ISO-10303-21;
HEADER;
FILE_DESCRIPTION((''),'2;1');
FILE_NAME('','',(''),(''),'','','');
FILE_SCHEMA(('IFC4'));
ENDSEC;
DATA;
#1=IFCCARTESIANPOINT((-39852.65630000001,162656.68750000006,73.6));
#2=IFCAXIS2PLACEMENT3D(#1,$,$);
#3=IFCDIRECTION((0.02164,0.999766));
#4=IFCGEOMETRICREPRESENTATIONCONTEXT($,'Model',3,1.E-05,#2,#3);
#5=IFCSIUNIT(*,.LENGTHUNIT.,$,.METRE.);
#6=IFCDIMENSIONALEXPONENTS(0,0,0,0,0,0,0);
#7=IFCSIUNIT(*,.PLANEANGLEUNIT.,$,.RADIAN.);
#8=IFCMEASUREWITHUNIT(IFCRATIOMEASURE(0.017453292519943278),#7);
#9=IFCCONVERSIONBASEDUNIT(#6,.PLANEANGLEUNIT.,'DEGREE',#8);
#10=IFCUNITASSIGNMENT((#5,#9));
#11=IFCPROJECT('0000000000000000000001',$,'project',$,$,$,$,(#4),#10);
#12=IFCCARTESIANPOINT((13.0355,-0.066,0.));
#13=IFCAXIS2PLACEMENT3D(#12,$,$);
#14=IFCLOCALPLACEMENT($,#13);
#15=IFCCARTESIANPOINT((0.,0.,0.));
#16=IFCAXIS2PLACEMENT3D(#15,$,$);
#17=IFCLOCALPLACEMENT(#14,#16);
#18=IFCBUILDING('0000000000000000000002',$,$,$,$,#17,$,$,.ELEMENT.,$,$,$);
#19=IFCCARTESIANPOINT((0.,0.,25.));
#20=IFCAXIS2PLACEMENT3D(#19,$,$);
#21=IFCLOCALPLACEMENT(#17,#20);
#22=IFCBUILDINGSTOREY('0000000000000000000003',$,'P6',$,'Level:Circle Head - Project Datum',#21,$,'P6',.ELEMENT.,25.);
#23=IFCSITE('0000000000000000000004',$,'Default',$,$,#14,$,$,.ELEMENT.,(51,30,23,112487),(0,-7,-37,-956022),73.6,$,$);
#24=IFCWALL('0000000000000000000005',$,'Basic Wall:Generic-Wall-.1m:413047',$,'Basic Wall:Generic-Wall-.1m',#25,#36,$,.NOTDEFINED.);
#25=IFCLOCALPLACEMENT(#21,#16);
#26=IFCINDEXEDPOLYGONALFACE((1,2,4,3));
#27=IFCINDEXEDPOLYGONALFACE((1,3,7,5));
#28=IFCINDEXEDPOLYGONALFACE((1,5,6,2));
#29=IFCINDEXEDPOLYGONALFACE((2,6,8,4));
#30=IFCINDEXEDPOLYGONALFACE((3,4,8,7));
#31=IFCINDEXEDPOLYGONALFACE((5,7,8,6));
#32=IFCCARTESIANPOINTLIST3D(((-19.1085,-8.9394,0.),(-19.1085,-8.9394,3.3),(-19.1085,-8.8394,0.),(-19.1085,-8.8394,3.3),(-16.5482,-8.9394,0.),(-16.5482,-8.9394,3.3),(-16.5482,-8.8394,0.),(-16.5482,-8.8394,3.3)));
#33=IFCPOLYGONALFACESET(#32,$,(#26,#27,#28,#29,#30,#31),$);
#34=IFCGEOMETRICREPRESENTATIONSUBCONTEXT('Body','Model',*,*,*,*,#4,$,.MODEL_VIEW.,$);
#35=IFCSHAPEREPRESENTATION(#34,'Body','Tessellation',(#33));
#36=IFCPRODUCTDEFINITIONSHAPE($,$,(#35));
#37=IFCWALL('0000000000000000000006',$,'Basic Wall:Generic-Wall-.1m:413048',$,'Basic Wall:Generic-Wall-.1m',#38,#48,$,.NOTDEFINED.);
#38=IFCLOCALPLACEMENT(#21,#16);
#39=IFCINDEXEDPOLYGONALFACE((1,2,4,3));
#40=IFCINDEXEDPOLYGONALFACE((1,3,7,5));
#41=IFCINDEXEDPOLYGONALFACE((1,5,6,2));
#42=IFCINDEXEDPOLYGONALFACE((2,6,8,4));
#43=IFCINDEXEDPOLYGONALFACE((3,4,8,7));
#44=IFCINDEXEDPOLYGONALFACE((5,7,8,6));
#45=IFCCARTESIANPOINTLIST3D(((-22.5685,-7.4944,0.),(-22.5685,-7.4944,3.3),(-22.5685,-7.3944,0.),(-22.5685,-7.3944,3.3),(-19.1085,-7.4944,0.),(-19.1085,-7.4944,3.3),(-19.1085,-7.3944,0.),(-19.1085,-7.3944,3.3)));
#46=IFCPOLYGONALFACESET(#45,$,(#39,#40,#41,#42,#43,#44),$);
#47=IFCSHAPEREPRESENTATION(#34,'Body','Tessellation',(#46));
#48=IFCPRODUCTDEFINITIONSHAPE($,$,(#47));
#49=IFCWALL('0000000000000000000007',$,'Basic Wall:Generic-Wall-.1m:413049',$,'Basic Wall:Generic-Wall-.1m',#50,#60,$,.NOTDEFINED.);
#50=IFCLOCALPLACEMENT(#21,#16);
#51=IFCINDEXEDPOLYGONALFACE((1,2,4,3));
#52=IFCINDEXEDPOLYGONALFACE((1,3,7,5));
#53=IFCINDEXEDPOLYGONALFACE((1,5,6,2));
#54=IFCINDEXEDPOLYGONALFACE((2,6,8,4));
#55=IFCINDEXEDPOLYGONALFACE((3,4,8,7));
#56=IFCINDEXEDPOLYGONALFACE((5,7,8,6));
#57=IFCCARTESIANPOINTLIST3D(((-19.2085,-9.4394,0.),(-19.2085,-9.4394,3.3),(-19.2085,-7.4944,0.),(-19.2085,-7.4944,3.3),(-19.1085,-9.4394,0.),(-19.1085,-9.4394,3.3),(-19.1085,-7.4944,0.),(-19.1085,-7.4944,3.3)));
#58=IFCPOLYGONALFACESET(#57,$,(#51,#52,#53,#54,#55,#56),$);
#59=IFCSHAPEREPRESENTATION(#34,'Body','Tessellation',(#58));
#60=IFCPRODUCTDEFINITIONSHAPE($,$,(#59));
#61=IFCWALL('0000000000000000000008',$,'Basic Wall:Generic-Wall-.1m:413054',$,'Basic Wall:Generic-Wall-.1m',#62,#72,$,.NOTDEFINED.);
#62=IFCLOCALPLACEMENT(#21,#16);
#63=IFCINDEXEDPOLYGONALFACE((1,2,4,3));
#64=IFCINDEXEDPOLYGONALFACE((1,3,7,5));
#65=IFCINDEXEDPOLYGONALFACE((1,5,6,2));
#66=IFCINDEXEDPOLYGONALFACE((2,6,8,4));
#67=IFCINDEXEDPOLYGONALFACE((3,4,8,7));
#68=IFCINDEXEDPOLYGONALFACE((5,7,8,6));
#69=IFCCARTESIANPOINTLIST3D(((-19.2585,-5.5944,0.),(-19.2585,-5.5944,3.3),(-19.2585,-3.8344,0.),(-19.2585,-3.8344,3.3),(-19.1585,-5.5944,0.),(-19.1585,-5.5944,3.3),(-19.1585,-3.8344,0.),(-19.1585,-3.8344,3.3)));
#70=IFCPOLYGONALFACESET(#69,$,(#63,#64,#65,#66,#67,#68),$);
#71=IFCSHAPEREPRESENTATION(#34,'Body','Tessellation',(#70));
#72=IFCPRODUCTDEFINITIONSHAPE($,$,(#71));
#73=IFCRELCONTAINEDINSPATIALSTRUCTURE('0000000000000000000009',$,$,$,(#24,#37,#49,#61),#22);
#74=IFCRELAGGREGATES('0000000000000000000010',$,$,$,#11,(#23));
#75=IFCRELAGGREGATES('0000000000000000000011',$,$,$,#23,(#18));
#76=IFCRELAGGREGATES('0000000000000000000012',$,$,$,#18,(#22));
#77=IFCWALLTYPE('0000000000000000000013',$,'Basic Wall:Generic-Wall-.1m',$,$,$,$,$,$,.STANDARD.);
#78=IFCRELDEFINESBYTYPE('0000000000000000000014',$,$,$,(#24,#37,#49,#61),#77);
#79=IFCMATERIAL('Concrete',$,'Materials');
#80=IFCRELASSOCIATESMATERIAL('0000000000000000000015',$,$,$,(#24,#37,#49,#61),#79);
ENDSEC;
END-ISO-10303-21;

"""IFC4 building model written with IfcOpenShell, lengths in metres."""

from ifc_helpers import new_model, entity, si_unit, converted_unit, direction, frame, origin, place, context, subcontext, project, spatial, indexed_curve, outline, extrude, material, type_object, element, save


model = new_model("IFC4")

# Units and contexts
model_context = context("Model", 3, precision=1e-05, world=frame((-39852.65630000001, 162656.68750000006, 73.6)), true_north=direction((0.02164, 0.999766)))
body_context = subcontext(model_context, "Body", "Model", "MODEL_VIEW")
ifc_project = project(units=[si_unit("LENGTHUNIT", "METRE"), converted_unit("PLANEANGLEUNIT", "DEGREE", entity("IfcRatioMeasure", 0.017453292519943278), si_unit("PLANEANGLEUNIT", "RADIAN"), dimensions=[0, 0, 0, 0, 0, 0, 0])], contexts=[model_context])

# Site, building, storey
site_placement = place(None, frame((13.0355, -0.066, 0.0)))
site = spatial("IfcSite", under=ifc_project, at=site_placement, Name="Default", CompositionType="ELEMENT", RefLatitude=(51, 30, 23, 112487), RefLongitude=(0, -7, -37, -956022), RefElevation=73.6)
building_placement = place(site_placement, origin())
building = spatial("IfcBuilding", under=site, at=building_placement, CompositionType="ELEMENT")
storey_placement = place(building_placement, frame((0.0, 0.0, 25.0)))
storey = spatial("IfcBuildingStorey", under=building, at=storey_placement, Name="P6", ObjectType="Level:Circle Head - Project Datum", LongName="P6", CompositionType="ELEMENT", Elevation=25.0)

# Shared definitions
ifc_material = material(Name="Concrete", Category="Materials")

# Walls
wall_type = type_object("IfcWallType", Name="Basic Wall:Generic-Wall-.1m", PredefinedType="STANDARD")
wall_1_placement = place(storey_placement, frame((-19.1085, -8.8894, 0.0)))
element("IfcWall", 1, at=wall_1_placement, inside=storey, type_object=wall_type, material=ifc_material, Name="Basic Wall:Generic-Wall-.1m:413047", ObjectType="Basic Wall:Generic-Wall-.1m", PredefinedType="NOTDEFINED", context=body_context, shape_type="SweptSolid", body=[
    extrude(outline(indexed_curve([(2.5602, 0.05), (0.0, 0.05), (0.0, -0.05), (2.5602, -0.05), (2.5602, 0.05)], self_intersect=False)), origin(), (0.0, 0.0, 1.0), 3.3),
])
wall_2_placement = place(storey_placement, frame((-22.5685, -7.4444, 0.0)))
element("IfcWall", 2, at=wall_2_placement, inside=storey, type_object=wall_type, material=ifc_material, Name="Basic Wall:Generic-Wall-.1m:413048", ObjectType="Basic Wall:Generic-Wall-.1m", PredefinedType="NOTDEFINED", context=body_context, shape_type="SweptSolid", body=[
    extrude(outline(indexed_curve([(3.46, 0.05), (0.0, 0.05), (0.0, -0.05), (3.46, -0.05), (3.46, 0.05)], self_intersect=False)), origin(), (0.0, 0.0, 1.0), 3.3),
])
wall_3_placement = place(storey_placement, frame((-19.1585, -7.4944, 0.0), z_axis=(0.0, 0.0, 1.0), x_axis=(0.0, -1.0, 0.0)))
element("IfcWall", 3, at=wall_3_placement, inside=storey, type_object=wall_type, material=ifc_material, Name="Basic Wall:Generic-Wall-.1m:413049", ObjectType="Basic Wall:Generic-Wall-.1m", PredefinedType="NOTDEFINED", context=body_context, shape_type="SweptSolid", body=[
    extrude(outline(indexed_curve([(1.945, 0.05), (0.0, 0.05), (0.0, -0.05), (1.945, -0.05), (1.945, 0.05)], self_intersect=False)), origin(), (0.0, 0.0, 1.0), 3.3),
])
wall_4_placement = place(storey_placement, frame((-19.2085, -5.5944, 0.0), z_axis=(0.0, 0.0, 1.0), x_axis=(0.0, 1.0, 0.0)))
element("IfcWall", 4, at=wall_4_placement, inside=storey, type_object=wall_type, material=ifc_material, Name="Basic Wall:Generic-Wall-.1m:413054", ObjectType="Basic Wall:Generic-Wall-.1m", PredefinedType="NOTDEFINED", context=body_context, shape_type="SweptSolid", body=[
    extrude(outline(indexed_curve([(1.76, 0.05), (0.0, 0.05), (0.0, -0.05), (1.76, -0.05), (1.76, 0.05)], self_intersect=False)), origin(), (0.0, 0.0, 1.0), 3.3),
])

save(model, "model.ifc")
